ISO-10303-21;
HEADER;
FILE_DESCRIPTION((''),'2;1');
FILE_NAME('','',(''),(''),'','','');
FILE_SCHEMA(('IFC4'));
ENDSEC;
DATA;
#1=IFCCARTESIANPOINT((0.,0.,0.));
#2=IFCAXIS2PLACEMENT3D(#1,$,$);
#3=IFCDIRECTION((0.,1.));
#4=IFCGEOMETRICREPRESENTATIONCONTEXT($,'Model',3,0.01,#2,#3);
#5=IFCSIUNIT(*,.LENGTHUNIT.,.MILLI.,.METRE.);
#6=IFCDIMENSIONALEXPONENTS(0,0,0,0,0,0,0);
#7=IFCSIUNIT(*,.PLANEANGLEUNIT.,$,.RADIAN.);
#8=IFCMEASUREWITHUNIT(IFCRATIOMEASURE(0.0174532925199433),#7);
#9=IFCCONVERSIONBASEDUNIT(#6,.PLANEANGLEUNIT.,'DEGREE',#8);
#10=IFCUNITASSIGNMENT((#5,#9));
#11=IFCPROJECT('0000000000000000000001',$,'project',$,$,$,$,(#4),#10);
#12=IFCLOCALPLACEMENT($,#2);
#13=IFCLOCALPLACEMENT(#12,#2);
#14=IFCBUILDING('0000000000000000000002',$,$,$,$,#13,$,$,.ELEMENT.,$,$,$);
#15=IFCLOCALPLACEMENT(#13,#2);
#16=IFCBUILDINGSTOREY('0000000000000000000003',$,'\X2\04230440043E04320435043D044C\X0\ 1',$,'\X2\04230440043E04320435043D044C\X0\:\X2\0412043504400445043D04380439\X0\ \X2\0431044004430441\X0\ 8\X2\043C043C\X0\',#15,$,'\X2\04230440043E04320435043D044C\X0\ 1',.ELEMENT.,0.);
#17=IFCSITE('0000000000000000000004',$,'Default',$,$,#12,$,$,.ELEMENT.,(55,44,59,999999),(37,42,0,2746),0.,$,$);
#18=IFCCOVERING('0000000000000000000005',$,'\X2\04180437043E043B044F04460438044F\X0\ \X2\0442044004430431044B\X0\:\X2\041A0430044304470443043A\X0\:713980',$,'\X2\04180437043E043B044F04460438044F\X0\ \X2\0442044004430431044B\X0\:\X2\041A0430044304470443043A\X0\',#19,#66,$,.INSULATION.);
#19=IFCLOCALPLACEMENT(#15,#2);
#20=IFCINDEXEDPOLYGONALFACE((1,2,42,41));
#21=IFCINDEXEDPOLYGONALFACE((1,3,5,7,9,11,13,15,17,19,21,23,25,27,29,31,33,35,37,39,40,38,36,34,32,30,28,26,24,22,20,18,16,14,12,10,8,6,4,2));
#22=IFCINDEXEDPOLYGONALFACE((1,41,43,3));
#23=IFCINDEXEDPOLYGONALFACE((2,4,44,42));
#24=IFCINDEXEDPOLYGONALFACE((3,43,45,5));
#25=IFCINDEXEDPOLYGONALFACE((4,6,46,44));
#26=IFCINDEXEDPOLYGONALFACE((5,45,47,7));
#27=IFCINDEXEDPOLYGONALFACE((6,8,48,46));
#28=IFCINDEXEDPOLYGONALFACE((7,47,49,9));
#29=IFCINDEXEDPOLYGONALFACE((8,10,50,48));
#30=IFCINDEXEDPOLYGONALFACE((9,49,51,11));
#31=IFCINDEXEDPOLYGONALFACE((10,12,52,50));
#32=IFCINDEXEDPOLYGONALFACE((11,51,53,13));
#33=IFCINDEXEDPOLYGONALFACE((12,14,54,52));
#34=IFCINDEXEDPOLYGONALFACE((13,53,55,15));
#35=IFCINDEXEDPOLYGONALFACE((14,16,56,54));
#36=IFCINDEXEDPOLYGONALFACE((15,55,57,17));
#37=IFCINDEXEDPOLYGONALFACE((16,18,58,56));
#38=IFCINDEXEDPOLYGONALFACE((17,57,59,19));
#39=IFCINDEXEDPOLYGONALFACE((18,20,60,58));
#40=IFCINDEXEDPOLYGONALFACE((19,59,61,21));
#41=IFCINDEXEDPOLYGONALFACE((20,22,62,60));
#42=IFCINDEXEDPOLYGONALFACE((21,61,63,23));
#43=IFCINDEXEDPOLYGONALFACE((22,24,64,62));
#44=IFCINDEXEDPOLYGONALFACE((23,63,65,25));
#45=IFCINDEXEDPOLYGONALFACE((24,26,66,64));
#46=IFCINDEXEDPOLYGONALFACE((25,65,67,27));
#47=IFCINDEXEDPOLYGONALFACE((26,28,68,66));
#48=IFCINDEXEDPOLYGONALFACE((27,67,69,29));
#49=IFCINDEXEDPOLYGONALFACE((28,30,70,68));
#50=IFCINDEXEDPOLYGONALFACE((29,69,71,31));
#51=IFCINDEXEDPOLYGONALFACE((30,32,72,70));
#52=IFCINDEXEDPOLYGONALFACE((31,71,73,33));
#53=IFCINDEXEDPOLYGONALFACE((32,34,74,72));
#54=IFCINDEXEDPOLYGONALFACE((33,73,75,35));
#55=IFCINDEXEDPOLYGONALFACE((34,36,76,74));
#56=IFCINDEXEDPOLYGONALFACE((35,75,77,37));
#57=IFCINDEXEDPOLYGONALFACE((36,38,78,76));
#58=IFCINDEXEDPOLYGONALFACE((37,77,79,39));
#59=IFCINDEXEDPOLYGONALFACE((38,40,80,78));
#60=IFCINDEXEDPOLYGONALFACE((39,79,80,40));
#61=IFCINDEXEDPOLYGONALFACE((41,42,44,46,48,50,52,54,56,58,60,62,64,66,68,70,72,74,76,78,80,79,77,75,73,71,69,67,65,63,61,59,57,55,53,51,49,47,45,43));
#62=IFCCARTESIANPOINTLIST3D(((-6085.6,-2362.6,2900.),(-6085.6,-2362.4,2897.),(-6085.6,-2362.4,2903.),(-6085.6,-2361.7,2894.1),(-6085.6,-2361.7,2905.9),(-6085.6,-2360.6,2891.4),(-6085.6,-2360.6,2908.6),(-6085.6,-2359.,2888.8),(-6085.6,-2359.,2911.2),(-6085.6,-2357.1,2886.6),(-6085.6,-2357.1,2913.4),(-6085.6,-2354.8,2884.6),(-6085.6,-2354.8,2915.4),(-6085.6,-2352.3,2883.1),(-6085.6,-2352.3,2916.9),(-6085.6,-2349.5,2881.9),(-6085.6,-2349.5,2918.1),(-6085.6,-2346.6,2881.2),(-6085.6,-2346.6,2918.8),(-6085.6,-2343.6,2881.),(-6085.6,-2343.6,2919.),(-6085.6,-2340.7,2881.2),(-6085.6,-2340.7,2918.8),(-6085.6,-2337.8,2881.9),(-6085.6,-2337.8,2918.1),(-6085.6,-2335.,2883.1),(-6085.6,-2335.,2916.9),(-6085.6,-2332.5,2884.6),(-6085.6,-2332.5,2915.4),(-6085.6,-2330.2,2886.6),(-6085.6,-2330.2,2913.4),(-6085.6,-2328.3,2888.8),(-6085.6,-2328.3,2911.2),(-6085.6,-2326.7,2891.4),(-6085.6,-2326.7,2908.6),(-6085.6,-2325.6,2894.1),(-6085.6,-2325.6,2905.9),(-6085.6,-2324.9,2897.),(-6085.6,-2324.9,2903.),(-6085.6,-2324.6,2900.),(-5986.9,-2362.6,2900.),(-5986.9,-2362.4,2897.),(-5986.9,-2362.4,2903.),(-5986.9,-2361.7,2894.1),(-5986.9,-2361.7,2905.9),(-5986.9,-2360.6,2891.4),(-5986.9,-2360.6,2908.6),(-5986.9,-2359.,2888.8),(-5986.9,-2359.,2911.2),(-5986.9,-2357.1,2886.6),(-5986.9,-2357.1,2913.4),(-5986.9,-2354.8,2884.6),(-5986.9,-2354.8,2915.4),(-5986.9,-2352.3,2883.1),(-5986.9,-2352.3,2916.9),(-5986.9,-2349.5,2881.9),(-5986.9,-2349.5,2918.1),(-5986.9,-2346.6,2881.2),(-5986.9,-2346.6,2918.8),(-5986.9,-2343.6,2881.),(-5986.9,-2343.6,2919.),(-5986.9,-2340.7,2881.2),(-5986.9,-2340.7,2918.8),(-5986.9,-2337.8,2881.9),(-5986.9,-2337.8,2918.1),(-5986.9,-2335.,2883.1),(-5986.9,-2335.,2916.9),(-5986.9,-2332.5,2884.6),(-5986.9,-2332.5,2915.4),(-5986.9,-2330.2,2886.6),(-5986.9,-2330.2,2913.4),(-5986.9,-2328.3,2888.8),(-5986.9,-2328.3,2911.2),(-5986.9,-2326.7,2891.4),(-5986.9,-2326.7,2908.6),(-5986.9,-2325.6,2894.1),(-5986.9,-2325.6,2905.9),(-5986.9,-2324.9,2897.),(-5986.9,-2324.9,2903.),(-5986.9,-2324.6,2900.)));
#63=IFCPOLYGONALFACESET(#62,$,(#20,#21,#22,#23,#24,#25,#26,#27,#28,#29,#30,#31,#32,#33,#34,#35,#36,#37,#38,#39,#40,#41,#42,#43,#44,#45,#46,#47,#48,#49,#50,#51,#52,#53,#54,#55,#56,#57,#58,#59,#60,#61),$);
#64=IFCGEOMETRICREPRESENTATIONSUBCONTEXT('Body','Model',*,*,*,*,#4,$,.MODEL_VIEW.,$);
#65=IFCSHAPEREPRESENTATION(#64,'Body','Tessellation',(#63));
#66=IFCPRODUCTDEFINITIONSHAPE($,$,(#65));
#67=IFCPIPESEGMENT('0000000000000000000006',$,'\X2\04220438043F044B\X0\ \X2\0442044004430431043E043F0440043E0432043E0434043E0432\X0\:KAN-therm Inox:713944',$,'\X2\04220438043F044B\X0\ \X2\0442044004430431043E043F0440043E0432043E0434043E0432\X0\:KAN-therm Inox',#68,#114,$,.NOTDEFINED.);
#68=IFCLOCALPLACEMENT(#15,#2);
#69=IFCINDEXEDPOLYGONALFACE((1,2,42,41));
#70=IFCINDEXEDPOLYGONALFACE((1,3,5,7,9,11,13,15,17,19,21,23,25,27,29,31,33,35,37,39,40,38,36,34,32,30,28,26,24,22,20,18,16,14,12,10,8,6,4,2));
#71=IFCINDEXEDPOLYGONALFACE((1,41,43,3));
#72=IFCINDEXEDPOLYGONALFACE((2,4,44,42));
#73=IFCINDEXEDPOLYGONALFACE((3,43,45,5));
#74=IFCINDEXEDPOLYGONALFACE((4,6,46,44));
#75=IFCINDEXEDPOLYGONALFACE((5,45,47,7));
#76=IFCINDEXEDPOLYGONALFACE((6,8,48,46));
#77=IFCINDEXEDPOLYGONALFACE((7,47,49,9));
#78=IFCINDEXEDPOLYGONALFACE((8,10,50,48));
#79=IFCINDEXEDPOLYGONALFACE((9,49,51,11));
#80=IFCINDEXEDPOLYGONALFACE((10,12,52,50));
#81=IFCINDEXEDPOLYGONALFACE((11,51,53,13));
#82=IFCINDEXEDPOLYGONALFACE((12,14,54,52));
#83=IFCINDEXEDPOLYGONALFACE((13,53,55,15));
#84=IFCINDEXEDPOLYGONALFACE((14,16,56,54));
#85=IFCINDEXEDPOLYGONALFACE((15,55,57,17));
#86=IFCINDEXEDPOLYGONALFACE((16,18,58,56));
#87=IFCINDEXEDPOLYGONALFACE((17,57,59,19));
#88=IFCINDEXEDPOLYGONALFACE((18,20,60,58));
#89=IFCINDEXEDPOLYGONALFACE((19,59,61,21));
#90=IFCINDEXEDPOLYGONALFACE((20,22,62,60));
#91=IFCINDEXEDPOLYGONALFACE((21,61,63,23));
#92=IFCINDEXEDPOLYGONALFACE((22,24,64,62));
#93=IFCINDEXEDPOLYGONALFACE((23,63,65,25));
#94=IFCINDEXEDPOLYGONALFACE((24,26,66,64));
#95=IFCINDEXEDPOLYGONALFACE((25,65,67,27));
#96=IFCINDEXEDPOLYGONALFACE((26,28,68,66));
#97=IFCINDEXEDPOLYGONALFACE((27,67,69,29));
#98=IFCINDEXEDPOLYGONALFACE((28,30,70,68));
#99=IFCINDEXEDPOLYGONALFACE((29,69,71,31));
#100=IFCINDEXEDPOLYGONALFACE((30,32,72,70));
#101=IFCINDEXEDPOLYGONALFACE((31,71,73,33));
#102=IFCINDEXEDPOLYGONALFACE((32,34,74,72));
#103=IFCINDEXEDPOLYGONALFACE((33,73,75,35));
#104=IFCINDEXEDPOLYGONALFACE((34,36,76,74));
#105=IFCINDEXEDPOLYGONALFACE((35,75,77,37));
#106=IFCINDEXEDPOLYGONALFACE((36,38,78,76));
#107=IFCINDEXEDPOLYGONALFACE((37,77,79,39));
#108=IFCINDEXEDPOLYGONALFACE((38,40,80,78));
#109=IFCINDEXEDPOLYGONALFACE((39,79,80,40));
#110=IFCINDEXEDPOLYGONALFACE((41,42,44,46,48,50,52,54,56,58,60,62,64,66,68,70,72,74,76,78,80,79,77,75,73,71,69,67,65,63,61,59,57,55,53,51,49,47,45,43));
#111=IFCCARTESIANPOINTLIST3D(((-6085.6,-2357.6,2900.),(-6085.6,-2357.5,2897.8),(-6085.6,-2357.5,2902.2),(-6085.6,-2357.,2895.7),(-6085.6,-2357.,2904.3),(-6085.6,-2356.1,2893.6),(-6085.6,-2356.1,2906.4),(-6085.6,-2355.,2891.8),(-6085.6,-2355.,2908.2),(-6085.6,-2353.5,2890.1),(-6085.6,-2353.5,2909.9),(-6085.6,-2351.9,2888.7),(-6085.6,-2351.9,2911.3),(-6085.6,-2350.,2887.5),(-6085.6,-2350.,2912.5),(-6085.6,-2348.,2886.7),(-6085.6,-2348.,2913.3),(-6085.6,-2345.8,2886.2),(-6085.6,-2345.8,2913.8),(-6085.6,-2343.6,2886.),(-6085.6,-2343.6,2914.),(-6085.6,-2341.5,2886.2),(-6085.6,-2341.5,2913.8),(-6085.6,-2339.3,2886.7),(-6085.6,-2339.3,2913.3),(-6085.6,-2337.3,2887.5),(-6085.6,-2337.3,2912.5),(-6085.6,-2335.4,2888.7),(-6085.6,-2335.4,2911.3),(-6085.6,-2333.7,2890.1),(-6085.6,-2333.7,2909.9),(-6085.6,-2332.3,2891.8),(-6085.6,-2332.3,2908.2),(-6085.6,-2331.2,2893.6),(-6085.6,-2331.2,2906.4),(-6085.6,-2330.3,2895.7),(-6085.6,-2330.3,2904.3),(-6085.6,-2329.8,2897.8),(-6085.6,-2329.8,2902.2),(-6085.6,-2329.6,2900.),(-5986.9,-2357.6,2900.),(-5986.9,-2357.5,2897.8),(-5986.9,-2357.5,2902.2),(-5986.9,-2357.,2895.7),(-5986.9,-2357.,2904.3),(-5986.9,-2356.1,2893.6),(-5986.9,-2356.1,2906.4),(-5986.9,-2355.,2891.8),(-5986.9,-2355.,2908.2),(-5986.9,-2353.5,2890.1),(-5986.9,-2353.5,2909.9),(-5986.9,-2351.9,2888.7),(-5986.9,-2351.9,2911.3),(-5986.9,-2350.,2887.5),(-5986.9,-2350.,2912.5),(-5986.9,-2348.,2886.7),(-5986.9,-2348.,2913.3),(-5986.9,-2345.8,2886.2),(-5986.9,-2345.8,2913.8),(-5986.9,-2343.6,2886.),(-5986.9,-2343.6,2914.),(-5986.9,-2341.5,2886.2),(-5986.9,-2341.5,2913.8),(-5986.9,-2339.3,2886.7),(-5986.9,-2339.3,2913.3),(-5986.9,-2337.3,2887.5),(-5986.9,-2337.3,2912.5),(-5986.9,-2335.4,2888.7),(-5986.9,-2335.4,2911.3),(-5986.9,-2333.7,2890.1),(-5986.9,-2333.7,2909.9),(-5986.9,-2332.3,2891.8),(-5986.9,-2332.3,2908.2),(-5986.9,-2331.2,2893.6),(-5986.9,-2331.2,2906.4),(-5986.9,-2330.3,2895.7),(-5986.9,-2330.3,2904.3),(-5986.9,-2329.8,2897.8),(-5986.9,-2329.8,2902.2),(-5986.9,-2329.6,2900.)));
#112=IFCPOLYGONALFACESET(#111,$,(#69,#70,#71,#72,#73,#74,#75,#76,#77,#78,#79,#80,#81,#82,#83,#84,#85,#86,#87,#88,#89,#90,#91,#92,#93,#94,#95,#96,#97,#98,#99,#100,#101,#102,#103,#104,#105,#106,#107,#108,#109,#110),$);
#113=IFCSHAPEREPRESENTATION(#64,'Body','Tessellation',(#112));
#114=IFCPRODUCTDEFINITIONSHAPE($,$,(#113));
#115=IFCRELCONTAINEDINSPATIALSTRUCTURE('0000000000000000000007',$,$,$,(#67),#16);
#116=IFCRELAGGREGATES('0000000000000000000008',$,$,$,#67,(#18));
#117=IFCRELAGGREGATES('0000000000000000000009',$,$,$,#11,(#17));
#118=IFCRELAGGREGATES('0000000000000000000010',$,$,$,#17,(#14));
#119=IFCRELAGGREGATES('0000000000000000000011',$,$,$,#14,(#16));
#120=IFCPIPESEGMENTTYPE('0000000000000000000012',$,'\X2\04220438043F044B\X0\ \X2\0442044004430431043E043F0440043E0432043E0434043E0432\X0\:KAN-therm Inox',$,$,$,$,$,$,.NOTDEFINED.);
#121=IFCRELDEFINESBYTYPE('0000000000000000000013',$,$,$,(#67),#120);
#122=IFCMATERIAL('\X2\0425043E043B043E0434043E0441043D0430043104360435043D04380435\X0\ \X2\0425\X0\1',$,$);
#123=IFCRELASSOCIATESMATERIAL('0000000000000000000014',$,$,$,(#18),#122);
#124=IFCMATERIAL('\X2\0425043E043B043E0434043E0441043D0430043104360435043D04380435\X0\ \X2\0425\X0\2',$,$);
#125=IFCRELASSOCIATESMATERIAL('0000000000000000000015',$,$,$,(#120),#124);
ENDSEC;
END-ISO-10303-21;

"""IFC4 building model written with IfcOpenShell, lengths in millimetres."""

from ifc_helpers import new_model, entity, si_unit, converted_unit, direction, frame, origin, place, context, subcontext, project, spatial, indexed_curve, outline, extrude, material, type_object, element, aggregate, save


model = new_model("IFC4")

# Units and contexts
model_context = context("Model", 3, precision=0.01, world=origin(), true_north=direction((0.0, 1.0)))
body_context = subcontext(model_context, "Body", "Model", "MODEL_VIEW")
ifc_project = project(units=[si_unit("LENGTHUNIT", "METRE", prefix="MILLI"), converted_unit("PLANEANGLEUNIT", "DEGREE", entity("IfcRatioMeasure", 0.0174532925199433), si_unit("PLANEANGLEUNIT", "RADIAN"), dimensions=[0, 0, 0, 0, 0, 0, 0])], contexts=[model_context])

# Site, building, storey
site_placement = place(None, origin())
site = spatial("IfcSite", under=ifc_project, at=site_placement, Name="Default", CompositionType="ELEMENT", RefLatitude=(55, 44, 59, 999999), RefLongitude=(37, 42, 0, 2746), RefElevation=0.0)
building_placement = place(site_placement, origin())
building = spatial("IfcBuilding", under=site, at=building_placement, CompositionType="ELEMENT")
storey_placement = place(building_placement, origin())
storey = spatial("IfcBuildingStorey", under=building, at=storey_placement, Name="Уровень 1", ObjectType="Уровень:Верхний брус 8мм", LongName="Уровень 1", CompositionType="ELEMENT", Elevation=0.0)

# Covering
ifc_material_1 = material(Name="Холодоснабжение Х2")
ifc_material_2 = material(Name="Холодоснабжение Х1")
covering_1_placement = place(storey_placement, origin())
covering_1 = element("IfcCovering", 1, at=covering_1_placement, material=ifc_material_2, Name="Изоляция трубы:Каучук:713980", ObjectType="Изоляция трубы:Каучук", PredefinedType="INSULATION", context=body_context, shape_type="SweptSolid", body=[
    extrude(outline(indexed_curve([(19.0, 0.0), (18.8, 3.0), (18.1, 5.9), (16.9, 8.6), (15.4, 11.2), (13.4, 13.4), (11.2, 15.4), (8.6, 16.9), (5.9, 18.1), (3.0, 18.8), (0.0, 19.0), (-3.0, 18.8), (-5.9, 18.1), (-8.6, 16.9), (-11.2, 15.4), (-13.4, 13.4), (-15.4, 11.2), (-16.9, 8.6), (-18.1, 5.9), (-18.8, 3.0), (-19.0, 0.0), (-18.8, -3.0), (-18.1, -5.9), (-16.9, -8.6), (-15.4, -11.2), (-13.4, -13.4), (-11.2, -15.4), (-8.6, -16.9), (-5.9, -18.1), (-3.0, -18.8), (0.0, -19.0), (3.0, -18.8), (5.9, -18.1), (8.6, -16.9), (11.2, -15.4), (13.4, -13.4), (15.4, -11.2), (16.9, -8.6), (18.1, -5.9), (18.8, -3.0), (19.0, 0.0)], self_intersect=False)), frame((-6085.6, -2343.6, 2900.0), z_axis=(1.0, 0.0, 0.0), x_axis=(0.0, -1.0, 0.0)), (0.0, 0.0, 1.0), 98.6),
])

# Pipe segment
pipe_segment_type_1 = type_object("IfcPipeSegmentType", Name="Типы трубопроводов:KAN-therm Inox", PredefinedType="NOTDEFINED", material=ifc_material_1)
pipe_segment_1_placement = place(storey_placement, origin())
pipe_segment_1 = element("IfcPipeSegment", 2, at=pipe_segment_1_placement, inside=storey, type_object=pipe_segment_type_1, Name="Типы трубопроводов:KAN-therm Inox:713944", ObjectType="Типы трубопроводов:KAN-therm Inox", PredefinedType="NOTDEFINED", context=body_context, shape_type="SweptSolid", body=[
    extrude(outline(indexed_curve([(14.0, 0.0), (13.8, 2.2), (13.3, 4.3), (12.5, 6.4), (11.3, 8.2), (9.9, 9.9), (8.2, 11.3), (6.4, 12.5), (4.3, 13.3), (2.2, 13.8), (0.0, 14.0), (-2.2, 13.8), (-4.3, 13.3), (-6.4, 12.5), (-8.2, 11.3), (-9.9, 9.9), (-11.3, 8.2), (-12.5, 6.4), (-13.3, 4.3), (-13.8, 2.2), (-14.0, 0.0), (-13.8, -2.2), (-13.3, -4.3), (-12.5, -6.4), (-11.3, -8.2), (-9.9, -9.9), (-8.2, -11.3), (-6.4, -12.5), (-4.3, -13.3), (-2.2, -13.8), (0.0, -14.0), (2.2, -13.8), (4.3, -13.3), (6.4, -12.5), (8.2, -11.3), (9.9, -9.9), (11.3, -8.2), (12.5, -6.4), (13.3, -4.3), (13.8, -2.2), (14.0, 0.0)], self_intersect=False)), frame((-6085.6, -2343.6, 2900.0), z_axis=(1.0, 0.0, 0.0), x_axis=(0.0, 1.0, 0.0)), (0.0, 0.0, 1.0), 98.6),
])
aggregate(pipe_segment_1, [covering_1])

save(model, "model.ifc")
